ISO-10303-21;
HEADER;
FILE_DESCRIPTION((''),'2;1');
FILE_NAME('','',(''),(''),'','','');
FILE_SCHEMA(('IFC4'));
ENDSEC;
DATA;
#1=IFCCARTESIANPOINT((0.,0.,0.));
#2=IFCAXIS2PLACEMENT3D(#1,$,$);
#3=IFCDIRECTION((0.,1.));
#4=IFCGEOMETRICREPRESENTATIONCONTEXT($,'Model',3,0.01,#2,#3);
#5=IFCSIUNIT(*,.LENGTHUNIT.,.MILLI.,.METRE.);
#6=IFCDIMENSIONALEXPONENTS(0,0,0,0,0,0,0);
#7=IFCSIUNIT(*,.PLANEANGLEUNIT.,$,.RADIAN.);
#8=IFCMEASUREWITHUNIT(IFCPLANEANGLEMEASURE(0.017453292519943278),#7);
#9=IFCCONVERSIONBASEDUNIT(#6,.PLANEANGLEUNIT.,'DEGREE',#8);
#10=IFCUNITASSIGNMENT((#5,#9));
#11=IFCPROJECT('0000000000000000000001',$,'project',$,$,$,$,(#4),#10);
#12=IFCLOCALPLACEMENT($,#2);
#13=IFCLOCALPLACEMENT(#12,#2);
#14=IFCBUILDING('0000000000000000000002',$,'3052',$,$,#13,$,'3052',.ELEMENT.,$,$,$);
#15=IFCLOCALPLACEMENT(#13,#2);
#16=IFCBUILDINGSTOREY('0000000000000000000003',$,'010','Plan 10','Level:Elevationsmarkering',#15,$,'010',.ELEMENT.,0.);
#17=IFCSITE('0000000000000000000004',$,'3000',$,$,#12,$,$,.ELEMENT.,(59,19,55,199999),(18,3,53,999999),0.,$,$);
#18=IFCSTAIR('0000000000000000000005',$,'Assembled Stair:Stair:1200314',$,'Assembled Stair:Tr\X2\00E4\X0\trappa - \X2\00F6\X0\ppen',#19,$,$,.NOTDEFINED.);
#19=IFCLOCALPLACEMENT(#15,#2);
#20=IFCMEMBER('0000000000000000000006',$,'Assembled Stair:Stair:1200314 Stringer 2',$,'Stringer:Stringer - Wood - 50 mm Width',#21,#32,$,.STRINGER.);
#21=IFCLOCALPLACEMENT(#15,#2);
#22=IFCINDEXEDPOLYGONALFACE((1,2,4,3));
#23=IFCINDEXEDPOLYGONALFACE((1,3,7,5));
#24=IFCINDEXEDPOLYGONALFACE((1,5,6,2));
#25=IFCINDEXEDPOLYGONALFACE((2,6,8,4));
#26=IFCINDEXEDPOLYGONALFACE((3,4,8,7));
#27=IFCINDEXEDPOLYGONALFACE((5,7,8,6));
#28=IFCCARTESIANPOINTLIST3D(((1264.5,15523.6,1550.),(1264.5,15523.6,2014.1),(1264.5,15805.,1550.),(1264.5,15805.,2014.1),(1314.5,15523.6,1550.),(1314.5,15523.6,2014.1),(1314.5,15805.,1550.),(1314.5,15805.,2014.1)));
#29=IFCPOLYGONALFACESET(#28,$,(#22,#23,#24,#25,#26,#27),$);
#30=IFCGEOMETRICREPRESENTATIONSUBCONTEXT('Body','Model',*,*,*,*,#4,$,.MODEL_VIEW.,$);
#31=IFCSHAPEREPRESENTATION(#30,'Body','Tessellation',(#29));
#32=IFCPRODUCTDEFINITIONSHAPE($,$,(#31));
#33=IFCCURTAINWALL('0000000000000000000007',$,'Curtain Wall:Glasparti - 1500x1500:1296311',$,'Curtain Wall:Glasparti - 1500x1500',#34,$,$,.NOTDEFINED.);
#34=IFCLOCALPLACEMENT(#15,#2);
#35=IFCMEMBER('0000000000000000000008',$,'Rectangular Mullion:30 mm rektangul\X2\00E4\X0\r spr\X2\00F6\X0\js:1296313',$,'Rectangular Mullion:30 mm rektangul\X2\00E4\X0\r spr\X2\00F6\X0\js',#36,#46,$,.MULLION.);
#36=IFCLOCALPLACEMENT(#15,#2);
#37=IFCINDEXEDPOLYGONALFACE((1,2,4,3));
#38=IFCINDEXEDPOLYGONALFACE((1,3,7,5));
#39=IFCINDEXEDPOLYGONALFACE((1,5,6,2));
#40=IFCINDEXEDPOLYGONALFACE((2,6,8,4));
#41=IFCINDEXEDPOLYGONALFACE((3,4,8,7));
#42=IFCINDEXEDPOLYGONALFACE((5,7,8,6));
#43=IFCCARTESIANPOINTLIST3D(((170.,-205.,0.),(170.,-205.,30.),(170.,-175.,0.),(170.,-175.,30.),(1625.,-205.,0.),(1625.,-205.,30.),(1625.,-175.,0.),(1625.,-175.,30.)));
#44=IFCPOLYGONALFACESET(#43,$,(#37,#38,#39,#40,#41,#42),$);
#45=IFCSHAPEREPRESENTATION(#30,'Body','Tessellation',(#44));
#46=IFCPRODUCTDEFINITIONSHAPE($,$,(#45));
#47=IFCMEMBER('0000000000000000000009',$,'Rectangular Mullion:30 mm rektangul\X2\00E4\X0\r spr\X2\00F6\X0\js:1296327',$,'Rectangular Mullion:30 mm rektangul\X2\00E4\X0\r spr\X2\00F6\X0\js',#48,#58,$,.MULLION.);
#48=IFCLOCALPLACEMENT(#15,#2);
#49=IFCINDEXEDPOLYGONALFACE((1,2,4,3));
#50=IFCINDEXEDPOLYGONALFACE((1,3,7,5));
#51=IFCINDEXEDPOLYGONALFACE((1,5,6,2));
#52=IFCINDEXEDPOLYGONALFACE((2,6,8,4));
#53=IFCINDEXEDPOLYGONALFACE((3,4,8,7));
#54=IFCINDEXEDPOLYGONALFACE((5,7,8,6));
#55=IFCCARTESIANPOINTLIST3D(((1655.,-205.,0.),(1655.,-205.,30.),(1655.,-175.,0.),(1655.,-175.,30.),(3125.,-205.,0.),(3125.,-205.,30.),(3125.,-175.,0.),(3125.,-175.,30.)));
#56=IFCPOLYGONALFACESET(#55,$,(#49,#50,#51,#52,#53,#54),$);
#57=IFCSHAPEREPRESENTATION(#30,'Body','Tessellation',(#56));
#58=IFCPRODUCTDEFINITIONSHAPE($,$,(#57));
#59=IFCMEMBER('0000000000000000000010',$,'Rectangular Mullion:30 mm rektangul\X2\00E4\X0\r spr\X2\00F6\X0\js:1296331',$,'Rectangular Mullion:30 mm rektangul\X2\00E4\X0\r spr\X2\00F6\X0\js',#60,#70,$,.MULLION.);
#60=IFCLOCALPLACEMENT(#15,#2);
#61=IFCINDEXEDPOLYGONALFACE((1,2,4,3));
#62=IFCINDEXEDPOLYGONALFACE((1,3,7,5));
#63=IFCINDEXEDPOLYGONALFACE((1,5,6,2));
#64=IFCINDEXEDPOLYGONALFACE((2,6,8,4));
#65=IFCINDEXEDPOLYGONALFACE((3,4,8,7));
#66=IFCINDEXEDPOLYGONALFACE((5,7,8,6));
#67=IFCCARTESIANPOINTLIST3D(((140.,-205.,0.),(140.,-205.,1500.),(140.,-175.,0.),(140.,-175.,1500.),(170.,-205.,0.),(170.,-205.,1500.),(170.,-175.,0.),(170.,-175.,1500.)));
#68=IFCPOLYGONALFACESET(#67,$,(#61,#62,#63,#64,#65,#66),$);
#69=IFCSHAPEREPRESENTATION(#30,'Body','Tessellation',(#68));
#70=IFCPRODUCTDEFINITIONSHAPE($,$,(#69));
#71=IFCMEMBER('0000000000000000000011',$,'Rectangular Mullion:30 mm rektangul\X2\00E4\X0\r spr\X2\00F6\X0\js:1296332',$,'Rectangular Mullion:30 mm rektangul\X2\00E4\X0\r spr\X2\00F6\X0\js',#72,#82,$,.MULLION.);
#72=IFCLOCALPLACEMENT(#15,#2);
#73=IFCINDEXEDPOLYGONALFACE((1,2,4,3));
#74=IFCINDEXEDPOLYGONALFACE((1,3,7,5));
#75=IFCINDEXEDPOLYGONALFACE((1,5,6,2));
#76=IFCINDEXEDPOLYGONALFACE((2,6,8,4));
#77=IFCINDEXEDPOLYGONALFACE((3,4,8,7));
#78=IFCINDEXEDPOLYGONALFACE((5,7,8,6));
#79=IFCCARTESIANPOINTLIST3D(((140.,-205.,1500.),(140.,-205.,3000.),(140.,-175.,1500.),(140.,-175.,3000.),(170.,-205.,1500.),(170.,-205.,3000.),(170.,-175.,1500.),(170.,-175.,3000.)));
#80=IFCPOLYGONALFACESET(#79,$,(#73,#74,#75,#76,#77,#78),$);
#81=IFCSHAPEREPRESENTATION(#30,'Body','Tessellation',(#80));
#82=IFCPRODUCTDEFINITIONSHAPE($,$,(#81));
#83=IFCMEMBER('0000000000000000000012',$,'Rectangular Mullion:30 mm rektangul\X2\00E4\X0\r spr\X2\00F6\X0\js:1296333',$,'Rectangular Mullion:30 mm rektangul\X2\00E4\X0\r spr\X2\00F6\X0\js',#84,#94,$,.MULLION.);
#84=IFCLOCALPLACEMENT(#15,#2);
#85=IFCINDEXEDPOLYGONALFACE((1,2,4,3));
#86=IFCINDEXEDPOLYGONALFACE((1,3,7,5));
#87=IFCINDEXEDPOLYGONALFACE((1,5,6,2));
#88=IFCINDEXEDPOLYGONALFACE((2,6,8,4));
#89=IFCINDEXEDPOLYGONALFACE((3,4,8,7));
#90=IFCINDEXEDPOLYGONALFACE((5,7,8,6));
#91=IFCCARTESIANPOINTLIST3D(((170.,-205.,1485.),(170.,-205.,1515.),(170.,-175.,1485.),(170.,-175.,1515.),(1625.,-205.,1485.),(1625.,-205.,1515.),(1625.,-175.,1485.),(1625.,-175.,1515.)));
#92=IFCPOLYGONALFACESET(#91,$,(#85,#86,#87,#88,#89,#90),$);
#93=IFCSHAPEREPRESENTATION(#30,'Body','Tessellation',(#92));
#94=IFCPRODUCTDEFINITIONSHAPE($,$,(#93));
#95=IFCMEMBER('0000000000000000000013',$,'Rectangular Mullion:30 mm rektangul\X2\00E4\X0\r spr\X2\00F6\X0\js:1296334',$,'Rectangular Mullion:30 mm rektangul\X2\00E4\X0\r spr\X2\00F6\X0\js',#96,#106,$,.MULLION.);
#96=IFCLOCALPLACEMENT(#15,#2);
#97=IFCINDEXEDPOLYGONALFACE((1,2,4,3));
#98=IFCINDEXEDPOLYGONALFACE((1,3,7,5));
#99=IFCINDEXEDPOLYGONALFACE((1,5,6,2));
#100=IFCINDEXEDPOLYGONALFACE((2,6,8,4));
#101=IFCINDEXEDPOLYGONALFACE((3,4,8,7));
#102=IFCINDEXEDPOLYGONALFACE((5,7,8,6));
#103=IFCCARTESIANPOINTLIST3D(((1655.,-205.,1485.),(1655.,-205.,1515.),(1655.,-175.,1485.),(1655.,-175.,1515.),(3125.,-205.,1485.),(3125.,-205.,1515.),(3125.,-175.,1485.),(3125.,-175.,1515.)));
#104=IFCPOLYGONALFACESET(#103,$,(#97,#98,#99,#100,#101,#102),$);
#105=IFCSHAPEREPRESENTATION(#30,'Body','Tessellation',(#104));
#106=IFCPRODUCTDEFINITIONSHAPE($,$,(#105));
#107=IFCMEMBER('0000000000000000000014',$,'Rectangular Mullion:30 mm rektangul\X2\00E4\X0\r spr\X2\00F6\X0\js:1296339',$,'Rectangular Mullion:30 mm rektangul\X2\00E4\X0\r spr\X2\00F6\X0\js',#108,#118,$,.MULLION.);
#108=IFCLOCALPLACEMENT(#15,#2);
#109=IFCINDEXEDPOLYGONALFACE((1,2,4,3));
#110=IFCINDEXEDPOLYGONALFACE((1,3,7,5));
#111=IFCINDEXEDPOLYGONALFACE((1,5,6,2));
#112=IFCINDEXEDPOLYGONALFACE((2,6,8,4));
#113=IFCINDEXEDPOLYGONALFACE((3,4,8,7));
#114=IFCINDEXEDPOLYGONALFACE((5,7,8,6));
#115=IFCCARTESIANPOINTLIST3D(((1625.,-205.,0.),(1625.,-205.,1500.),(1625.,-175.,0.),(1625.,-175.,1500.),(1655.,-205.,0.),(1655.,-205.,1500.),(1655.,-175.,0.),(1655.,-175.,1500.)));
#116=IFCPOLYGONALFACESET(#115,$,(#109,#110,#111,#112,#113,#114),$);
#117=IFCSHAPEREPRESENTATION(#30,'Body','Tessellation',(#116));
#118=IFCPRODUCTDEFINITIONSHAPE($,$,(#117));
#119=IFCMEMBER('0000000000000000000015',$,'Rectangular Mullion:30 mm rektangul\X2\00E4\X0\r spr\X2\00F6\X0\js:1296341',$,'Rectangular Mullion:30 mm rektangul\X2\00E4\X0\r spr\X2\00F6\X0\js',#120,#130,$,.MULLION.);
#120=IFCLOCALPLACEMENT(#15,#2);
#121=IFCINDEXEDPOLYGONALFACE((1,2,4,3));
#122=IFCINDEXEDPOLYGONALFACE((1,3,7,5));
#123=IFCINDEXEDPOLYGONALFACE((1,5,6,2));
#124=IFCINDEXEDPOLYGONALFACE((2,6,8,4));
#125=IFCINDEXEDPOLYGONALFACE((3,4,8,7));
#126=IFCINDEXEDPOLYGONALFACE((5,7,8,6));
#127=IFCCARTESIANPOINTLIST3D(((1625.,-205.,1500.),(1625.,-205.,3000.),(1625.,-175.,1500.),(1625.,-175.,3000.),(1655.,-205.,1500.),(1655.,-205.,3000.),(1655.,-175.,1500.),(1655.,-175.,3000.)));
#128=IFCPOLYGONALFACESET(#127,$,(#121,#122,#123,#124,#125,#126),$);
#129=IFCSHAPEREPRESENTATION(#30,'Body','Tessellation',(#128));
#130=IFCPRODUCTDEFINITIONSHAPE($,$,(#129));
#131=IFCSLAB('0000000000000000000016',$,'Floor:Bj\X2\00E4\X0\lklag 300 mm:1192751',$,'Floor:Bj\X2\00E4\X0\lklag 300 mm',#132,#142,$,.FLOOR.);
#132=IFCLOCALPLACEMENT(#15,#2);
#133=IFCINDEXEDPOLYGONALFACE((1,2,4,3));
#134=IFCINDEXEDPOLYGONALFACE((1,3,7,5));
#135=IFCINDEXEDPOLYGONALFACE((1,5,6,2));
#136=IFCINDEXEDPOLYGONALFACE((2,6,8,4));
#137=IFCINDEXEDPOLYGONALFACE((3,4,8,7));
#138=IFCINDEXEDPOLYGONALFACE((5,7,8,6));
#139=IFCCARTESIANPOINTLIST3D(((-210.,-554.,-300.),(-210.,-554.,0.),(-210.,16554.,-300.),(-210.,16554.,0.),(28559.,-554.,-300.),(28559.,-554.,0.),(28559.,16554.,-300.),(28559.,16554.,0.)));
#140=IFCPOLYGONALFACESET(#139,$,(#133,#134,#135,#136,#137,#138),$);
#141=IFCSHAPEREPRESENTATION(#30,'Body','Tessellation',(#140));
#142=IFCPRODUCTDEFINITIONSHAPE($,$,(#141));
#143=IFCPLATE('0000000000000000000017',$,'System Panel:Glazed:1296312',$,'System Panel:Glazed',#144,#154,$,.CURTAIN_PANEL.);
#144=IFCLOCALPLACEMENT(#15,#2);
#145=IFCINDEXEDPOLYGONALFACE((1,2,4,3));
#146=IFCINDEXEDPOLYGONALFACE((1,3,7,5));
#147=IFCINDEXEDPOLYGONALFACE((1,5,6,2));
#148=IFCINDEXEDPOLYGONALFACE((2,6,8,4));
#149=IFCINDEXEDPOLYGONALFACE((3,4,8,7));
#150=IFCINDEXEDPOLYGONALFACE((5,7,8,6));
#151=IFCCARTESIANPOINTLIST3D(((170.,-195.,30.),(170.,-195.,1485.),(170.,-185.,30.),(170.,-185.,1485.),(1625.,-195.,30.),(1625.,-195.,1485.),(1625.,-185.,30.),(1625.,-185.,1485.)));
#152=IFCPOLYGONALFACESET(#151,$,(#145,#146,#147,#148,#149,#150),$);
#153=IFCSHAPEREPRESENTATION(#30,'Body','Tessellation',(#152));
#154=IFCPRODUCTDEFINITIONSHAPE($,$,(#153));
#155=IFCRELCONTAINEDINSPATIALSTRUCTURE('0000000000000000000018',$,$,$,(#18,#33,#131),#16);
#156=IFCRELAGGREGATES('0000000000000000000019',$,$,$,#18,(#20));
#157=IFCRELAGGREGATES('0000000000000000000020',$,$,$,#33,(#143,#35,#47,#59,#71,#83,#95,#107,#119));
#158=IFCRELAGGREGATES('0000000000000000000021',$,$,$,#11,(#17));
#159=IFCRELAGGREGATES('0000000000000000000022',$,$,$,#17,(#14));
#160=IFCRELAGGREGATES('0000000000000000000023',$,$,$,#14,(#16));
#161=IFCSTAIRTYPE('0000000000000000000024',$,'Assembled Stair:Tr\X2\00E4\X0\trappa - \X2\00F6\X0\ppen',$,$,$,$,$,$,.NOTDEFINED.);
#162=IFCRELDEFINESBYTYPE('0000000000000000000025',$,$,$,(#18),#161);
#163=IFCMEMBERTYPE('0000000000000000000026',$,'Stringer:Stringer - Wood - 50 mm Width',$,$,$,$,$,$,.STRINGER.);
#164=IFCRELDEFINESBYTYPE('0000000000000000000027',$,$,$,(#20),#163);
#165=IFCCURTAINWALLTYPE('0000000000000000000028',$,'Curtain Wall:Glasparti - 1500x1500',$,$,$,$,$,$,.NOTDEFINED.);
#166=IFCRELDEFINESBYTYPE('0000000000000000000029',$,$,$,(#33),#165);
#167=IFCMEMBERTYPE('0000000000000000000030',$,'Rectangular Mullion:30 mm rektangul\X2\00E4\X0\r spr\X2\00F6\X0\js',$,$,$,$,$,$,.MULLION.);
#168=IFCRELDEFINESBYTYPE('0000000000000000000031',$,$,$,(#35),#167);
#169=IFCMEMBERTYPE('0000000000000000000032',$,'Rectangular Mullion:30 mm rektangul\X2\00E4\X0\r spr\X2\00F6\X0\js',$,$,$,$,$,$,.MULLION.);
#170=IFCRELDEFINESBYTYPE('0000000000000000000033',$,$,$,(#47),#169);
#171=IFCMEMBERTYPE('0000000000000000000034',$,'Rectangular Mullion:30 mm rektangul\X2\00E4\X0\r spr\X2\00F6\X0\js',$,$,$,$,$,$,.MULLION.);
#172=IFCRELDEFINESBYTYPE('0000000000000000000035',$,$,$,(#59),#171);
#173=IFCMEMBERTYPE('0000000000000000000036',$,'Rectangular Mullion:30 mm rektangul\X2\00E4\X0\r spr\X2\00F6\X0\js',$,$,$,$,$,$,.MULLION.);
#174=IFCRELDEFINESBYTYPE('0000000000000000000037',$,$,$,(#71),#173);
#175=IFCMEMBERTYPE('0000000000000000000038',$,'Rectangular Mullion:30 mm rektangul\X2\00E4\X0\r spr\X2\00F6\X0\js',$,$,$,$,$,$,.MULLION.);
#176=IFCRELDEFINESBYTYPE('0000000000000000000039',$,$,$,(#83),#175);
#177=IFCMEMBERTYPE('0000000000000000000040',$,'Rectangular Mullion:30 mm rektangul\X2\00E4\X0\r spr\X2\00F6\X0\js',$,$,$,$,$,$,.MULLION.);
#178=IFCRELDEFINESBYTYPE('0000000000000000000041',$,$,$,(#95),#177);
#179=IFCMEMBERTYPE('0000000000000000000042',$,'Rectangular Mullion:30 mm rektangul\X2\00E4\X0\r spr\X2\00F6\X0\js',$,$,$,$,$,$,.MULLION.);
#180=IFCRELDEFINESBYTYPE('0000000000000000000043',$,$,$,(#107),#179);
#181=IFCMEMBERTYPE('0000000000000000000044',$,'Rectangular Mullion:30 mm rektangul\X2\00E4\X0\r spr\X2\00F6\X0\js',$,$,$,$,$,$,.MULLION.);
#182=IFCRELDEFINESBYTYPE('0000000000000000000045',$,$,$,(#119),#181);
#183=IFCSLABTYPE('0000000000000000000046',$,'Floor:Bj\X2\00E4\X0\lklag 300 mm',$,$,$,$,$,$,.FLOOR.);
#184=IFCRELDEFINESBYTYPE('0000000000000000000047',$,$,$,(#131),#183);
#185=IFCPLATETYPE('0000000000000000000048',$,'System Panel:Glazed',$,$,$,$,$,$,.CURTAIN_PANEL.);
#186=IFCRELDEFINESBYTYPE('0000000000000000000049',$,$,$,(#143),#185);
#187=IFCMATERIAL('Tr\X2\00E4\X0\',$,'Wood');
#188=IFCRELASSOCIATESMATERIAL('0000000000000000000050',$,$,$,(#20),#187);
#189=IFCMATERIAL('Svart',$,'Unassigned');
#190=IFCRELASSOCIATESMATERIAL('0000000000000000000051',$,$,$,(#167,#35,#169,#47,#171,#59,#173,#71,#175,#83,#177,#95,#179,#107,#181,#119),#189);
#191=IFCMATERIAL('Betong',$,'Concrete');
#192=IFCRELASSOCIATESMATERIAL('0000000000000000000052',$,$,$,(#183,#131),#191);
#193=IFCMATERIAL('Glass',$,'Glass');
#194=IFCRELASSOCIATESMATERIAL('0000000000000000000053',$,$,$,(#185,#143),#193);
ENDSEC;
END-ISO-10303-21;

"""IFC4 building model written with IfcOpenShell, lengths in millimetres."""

from ifc_helpers import new_model, entity, si_unit, converted_unit, direction, frame, origin, place, context, subcontext, project, spatial, indexed_curve, outline, extrude, source, transform, mapped, material, type_object, type_shapes, element, aggregate, save


model = new_model("IFC4")

# Units and contexts
model_context = context("Model", 3, precision=0.01, world=origin(), true_north=direction((0.0, 1.0)))
body_context = subcontext(model_context, "Body", "Model", "MODEL_VIEW")
ifc_project = project(units=[si_unit("LENGTHUNIT", "METRE", prefix="MILLI"), converted_unit("PLANEANGLEUNIT", "DEGREE", entity("IfcPlaneAngleMeasure", 0.017453292519943278), si_unit("PLANEANGLEUNIT", "RADIAN"), dimensions=[0, 0, 0, 0, 0, 0, 0])], contexts=[model_context])

# Site, building, storey
site_placement = place(None, origin())
site = spatial("IfcSite", under=ifc_project, at=site_placement, Name="3000", CompositionType="ELEMENT", RefLatitude=(59, 19, 55, 199999), RefLongitude=(18, 3, 53, 999999), RefElevation=0.0)
building_placement = place(site_placement, origin())
building = spatial("IfcBuilding", under=site, at=building_placement, Name="3052", LongName="3052", CompositionType="ELEMENT")
storey_placement = place(building_placement, origin())
storey = spatial("IfcBuildingStorey", under=building, at=storey_placement, Name="010", Description="Plan 10", ObjectType="Level:Elevationsmarkering", LongName="010", CompositionType="ELEMENT", Elevation=0.0)

# Stair, member
stair_type = type_object("IfcStairType", Name="Assembled Stair:Trätrappa - öppen", PredefinedType="NOTDEFINED")
stair_placement = place(storey_placement, origin())
stair = element("IfcStair", 1, at=stair_placement, inside=storey, type_object=stair_type, Name="Assembled Stair:Stair:1200314", ObjectType="Assembled Stair:Trätrappa - öppen", PredefinedType="NOTDEFINED")
ifc_material_1 = material(Name="Trä", Category="Wood")
member_type_1 = type_object("IfcMemberType", Name="Stringer:Stringer - Wood - 50 mm Width", PredefinedType="STRINGER")
member_1_placement = place(stair_placement, origin())
member_1 = element("IfcMember", 2, at=member_1_placement, type_object=member_type_1, material=ifc_material_1, Name="Assembled Stair:Stair:1200314 Stringer 2", ObjectType="Stringer:Stringer - Wood - 50 mm Width", PredefinedType="STRINGER", context=body_context, shape_type="SweptSolid", body=[
    extrude(outline(indexed_curve([(-140.7, -25.0), (140.7, -25.0), (140.7, 25.0), (-140.7, 25.0), (-140.7, -25.0)], self_intersect=False)), frame((1289.5, 15664.3, 1550.0), z_axis=(0.0, 0.0, 1.0), x_axis=(0.0, 1.0, 0.0)), (0.0, 0.0, 1.0), 464.1),
])
aggregate(stair, [member_1])

# Curtain wall, members
curtain_wall_type = type_object("IfcCurtainWallType", Name="Curtain Wall:Glasparti - 1500x1500", PredefinedType="NOTDEFINED")
curtain_wall_placement = place(storey_placement, origin())
curtain_wall = element("IfcCurtainWall", 3, at=curtain_wall_placement, inside=storey, type_object=curtain_wall_type, Name="Curtain Wall:Glasparti - 1500x1500:1296311", ObjectType="Curtain Wall:Glasparti - 1500x1500", PredefinedType="NOTDEFINED")
ifc_material_2 = material(Name="Svart", Category="Unassigned")
member_type_2 = type_object("IfcMemberType", Name="Rectangular Mullion:30 mm rektangulär spröjs", PredefinedType="MULLION", material=ifc_material_2)
shared_shape_1 = source(origin(), body_context, "Body", "SweptSolid", [
    extrude(outline(indexed_curve([(-15.0, -15.0), (15.0, -15.0), (15.0, 15.0), (-15.0, 15.0), (-15.0, -15.0)], self_intersect=False)), frame((-15.0, 0.0, -1455.0), z_axis=(0.0, 0.0, 1.0), x_axis=(-1.0, 0.0, 0.0)), (0.0, 0.0, 1.0), 1455.0),
])
type_shapes(member_type_2, [shared_shape_1])
member_2_placement = place(curtain_wall_placement, frame((170.0, -190.0, 0.0), z_axis=(-1.0, 0.0, 0.0), x_axis=(0.0, 0.0, -1.0)))
member_2 = element("IfcMember", 4, at=member_2_placement, type_object=member_type_2, material=ifc_material_2, Name="Rectangular Mullion:30 mm rektangulär spröjs:1296313", ObjectType="Rectangular Mullion:30 mm rektangulär spröjs", PredefinedType="MULLION", context=body_context, shape_type="MappedRepresentation", body=[
    mapped(shared_shape_1, transform((0.0, 0.0, 0.0), scale=1.0)),
])
member_type_3 = type_object("IfcMemberType", Name="Rectangular Mullion:30 mm rektangulär spröjs", PredefinedType="MULLION", material=ifc_material_2)
shared_shape_2 = source(origin(), body_context, "Body", "SweptSolid", [
    extrude(outline(indexed_curve([(-15.0, -15.0), (15.0, -15.0), (15.0, 15.0), (-15.0, 15.0), (-15.0, -15.0)], self_intersect=False)), frame((-15.0, 0.0, -1470.0), z_axis=(0.0, 0.0, 1.0), x_axis=(-1.0, 0.0, 0.0)), (0.0, 0.0, 1.0), 1470.0),
])
type_shapes(member_type_3, [shared_shape_2])
member_3_placement = place(curtain_wall_placement, frame((1655.0, -190.0, 0.0), z_axis=(-1.0, 0.0, 0.0), x_axis=(0.0, 0.0, -1.0)))
member_3 = element("IfcMember", 5, at=member_3_placement, type_object=member_type_3, material=ifc_material_2, Name="Rectangular Mullion:30 mm rektangulär spröjs:1296327", ObjectType="Rectangular Mullion:30 mm rektangulär spröjs", PredefinedType="MULLION", context=body_context, shape_type="MappedRepresentation", body=[
    mapped(shared_shape_2, transform((0.0, 0.0, 0.0), scale=1.0)),
])
member_type_4 = type_object("IfcMemberType", Name="Rectangular Mullion:30 mm rektangulär spröjs", PredefinedType="MULLION", material=ifc_material_2)
shared_shape_3 = source(origin(), body_context, "Body", "SweptSolid", [
    extrude(outline(indexed_curve([(-15.0, -15.0), (15.0, -15.0), (15.0, 15.0), (-15.0, 15.0), (-15.0, -15.0)], self_intersect=False)), frame((-15.0, 0.0, -1500.0), z_axis=(0.0, 0.0, 1.0), x_axis=(-1.0, 0.0, 0.0)), (0.0, 0.0, 1.0), 1500.0),
])
type_shapes(member_type_4, [shared_shape_3])
member_4_placement = place(curtain_wall_placement, frame((140.0, -190.0, 1500.0), z_axis=(0.0, 0.0, 1.0), x_axis=(-1.0, 0.0, 0.0)))
member_4 = element("IfcMember", 6, at=member_4_placement, type_object=member_type_4, material=ifc_material_2, Name="Rectangular Mullion:30 mm rektangulär spröjs:1296331", ObjectType="Rectangular Mullion:30 mm rektangulär spröjs", PredefinedType="MULLION", context=body_context, shape_type="MappedRepresentation", body=[
    mapped(shared_shape_3, transform((0.0, 0.0, 0.0), scale=1.0)),
])
member_type_5 = type_object("IfcMemberType", Name="Rectangular Mullion:30 mm rektangulär spröjs", PredefinedType="MULLION", material=ifc_material_2)
shared_shape_4 = source(origin(), body_context, "Body", "SweptSolid", [
    extrude(outline(indexed_curve([(-15.0, -15.0), (15.0, -15.0), (15.0, 15.0), (-15.0, 15.0), (-15.0, -15.0)], self_intersect=False)), frame((-15.0, 0.0, -1500.0), z_axis=(0.0, 0.0, 1.0), x_axis=(-1.0, 0.0, 0.0)), (0.0, 0.0, 1.0), 1500.0),
])
type_shapes(member_type_5, [shared_shape_4])
member_5_placement = place(curtain_wall_placement, frame((140.0, -190.0, 3000.0), z_axis=(0.0, 0.0, 1.0), x_axis=(-1.0, 0.0, 0.0)))
member_5 = element("IfcMember", 7, at=member_5_placement, type_object=member_type_5, material=ifc_material_2, Name="Rectangular Mullion:30 mm rektangulär spröjs:1296332", ObjectType="Rectangular Mullion:30 mm rektangulär spröjs", PredefinedType="MULLION", context=body_context, shape_type="MappedRepresentation", body=[
    mapped(shared_shape_4, transform((0.0, 0.0, 0.0), scale=1.0)),
])
member_type_6 = type_object("IfcMemberType", Name="Rectangular Mullion:30 mm rektangulär spröjs", PredefinedType="MULLION", material=ifc_material_2)
shared_shape_5 = source(origin(), body_context, "Body", "SweptSolid", [
    extrude(outline(indexed_curve([(-15.0, -15.0), (15.0, -15.0), (15.0, 15.0), (-15.0, 15.0), (-15.0, -15.0)], self_intersect=False)), frame((0.0, 0.0, -1455.0), z_axis=(0.0, 0.0, 1.0), x_axis=(-1.0, 0.0, 0.0)), (0.0, 0.0, 1.0), 1455.0),
])
type_shapes(member_type_6, [shared_shape_5])
member_6_placement = place(curtain_wall_placement, frame((1625.0, -190.0, 1500.0), z_axis=(1.0, 0.0, 0.0), x_axis=(0.0, 0.0, 1.0)))
member_6 = element("IfcMember", 8, at=member_6_placement, type_object=member_type_6, material=ifc_material_2, Name="Rectangular Mullion:30 mm rektangulär spröjs:1296333", ObjectType="Rectangular Mullion:30 mm rektangulär spröjs", PredefinedType="MULLION", context=body_context, shape_type="MappedRepresentation", body=[
    mapped(shared_shape_5, transform((0.0, 0.0, 0.0), scale=1.0)),
])
member_type_7 = type_object("IfcMemberType", Name="Rectangular Mullion:30 mm rektangulär spröjs", PredefinedType="MULLION", material=ifc_material_2)
shared_shape_6 = source(origin(), body_context, "Body", "SweptSolid", [
    extrude(outline(indexed_curve([(-15.0, -15.0), (15.0, -15.0), (15.0, 15.0), (-15.0, 15.0), (-15.0, -15.0)], self_intersect=False)), frame((0.0, 0.0, -1470.0), z_axis=(0.0, 0.0, 1.0), x_axis=(-1.0, 0.0, 0.0)), (0.0, 0.0, 1.0), 1470.0),
])
type_shapes(member_type_7, [shared_shape_6])
member_7_placement = place(curtain_wall_placement, frame((3125.0, -190.0, 1500.0), z_axis=(1.0, 0.0, 0.0), x_axis=(0.0, 0.0, 1.0)))
member_7 = element("IfcMember", 9, at=member_7_placement, type_object=member_type_7, material=ifc_material_2, Name="Rectangular Mullion:30 mm rektangulär spröjs:1296334", ObjectType="Rectangular Mullion:30 mm rektangulär spröjs", PredefinedType="MULLION", context=body_context, shape_type="MappedRepresentation", body=[
    mapped(shared_shape_6, transform((0.0, 0.0, 0.0), scale=1.0)),
])
member_type_8 = type_object("IfcMemberType", Name="Rectangular Mullion:30 mm rektangulär spröjs", PredefinedType="MULLION", material=ifc_material_2)
shared_shape_7 = source(origin(), body_context, "Body", "SweptSolid", [
    extrude(outline(indexed_curve([(-15.0, -15.0), (15.0, -15.0), (15.0, 15.0), (-15.0, 15.0), (-15.0, -15.0)], self_intersect=False)), frame((0.0, 0.0, -1500.0), z_axis=(0.0, 0.0, 1.0), x_axis=(-1.0, 0.0, 0.0)), (0.0, 0.0, 1.0), 1500.0),
])
type_shapes(member_type_8, [shared_shape_7])
member_8_placement = place(curtain_wall_placement, frame((1640.0, -190.0, 0.0), z_axis=(0.0, 0.0, -1.0), x_axis=(1.0, 0.0, 0.0)))
member_8 = element("IfcMember", 10, at=member_8_placement, type_object=member_type_8, material=ifc_material_2, Name="Rectangular Mullion:30 mm rektangulär spröjs:1296339", ObjectType="Rectangular Mullion:30 mm rektangulär spröjs", PredefinedType="MULLION", context=body_context, shape_type="MappedRepresentation", body=[
    mapped(shared_shape_7, transform((0.0, 0.0, 0.0), scale=1.0)),
])
member_type_9 = type_object("IfcMemberType", Name="Rectangular Mullion:30 mm rektangulär spröjs", PredefinedType="MULLION", material=ifc_material_2)
shared_shape_8 = source(origin(), body_context, "Body", "SweptSolid", [
    extrude(outline(indexed_curve([(-15.0, -15.0), (15.0, -15.0), (15.0, 15.0), (-15.0, 15.0), (-15.0, -15.0)], self_intersect=False)), frame((0.0, 0.0, -1500.0), z_axis=(0.0, 0.0, 1.0), x_axis=(-1.0, 0.0, 0.0)), (0.0, 0.0, 1.0), 1500.0),
])
type_shapes(member_type_9, [shared_shape_8])
member_9_placement = place(curtain_wall_placement, frame((1640.0, -190.0, 1500.0), z_axis=(0.0, 0.0, -1.0), x_axis=(1.0, 0.0, 0.0)))
member_9 = element("IfcMember", 11, at=member_9_placement, type_object=member_type_9, material=ifc_material_2, Name="Rectangular Mullion:30 mm rektangulär spröjs:1296341", ObjectType="Rectangular Mullion:30 mm rektangulär spröjs", PredefinedType="MULLION", context=body_context, shape_type="MappedRepresentation", body=[
    mapped(shared_shape_8, transform((0.0, 0.0, 0.0), scale=1.0)),
])

# Slab
ifc_material_3 = material(Name="Betong", Category="Concrete")
slab_type = type_object("IfcSlabType", Name="Floor:Bjälklag 300 mm", PredefinedType="FLOOR", material=ifc_material_3)
slab_placement = place(storey_placement, origin())
element("IfcSlab", 12, at=slab_placement, inside=storey, type_object=slab_type, material=ifc_material_3, Name="Floor:Bjälklag 300 mm:1192751", ObjectType="Floor:Bjälklag 300 mm", PredefinedType="FLOOR", context=body_context, shape_type="SweptSolid", body=[
    extrude(outline(indexed_curve([(-8554.0, -14384.5), (8554.0, -14384.5), (8554.0, 14384.5), (-8554.0, 14384.5), (-8554.0, -14384.5)], self_intersect=False)), frame((14174.5, 8000.0, 0.0), z_axis=(0.0, 0.0, -1.0), x_axis=(0.0, 1.0, 0.0)), (0.0, 0.0, 1.0), 300.0),
])

# Plate
ifc_material_4 = material(Name="Glass", Category="Glass")
plate_type_1 = type_object("IfcPlateType", Name="System Panel:Glazed", PredefinedType="CURTAIN_PANEL", material=ifc_material_4)
shared_shape_9 = source(origin(), body_context, "Body", "SweptSolid", [
    extrude(outline(indexed_curve([(-5.0, -727.5), (5.0, -727.5), (5.0, 727.5), (-5.0, 727.5), (-5.0, -727.5)], self_intersect=False)), frame((0.0, 0.0, 0.0), z_axis=(0.0, 0.0, 1.0), x_axis=(0.0, 1.0, 0.0)), (0.0, 0.0, 1.0), 1455.0),
])
type_shapes(plate_type_1, [shared_shape_9])
plate_1_placement = place(curtain_wall_placement, frame((897.5, -190.0, 30.0)))
plate_1 = element("IfcPlate", 13, at=plate_1_placement, type_object=plate_type_1, material=ifc_material_4, Name="System Panel:Glazed:1296312", ObjectType="System Panel:Glazed", PredefinedType="CURTAIN_PANEL", context=body_context, shape_type="MappedRepresentation", body=[
    mapped(shared_shape_9, transform((0.0, 0.0, 0.0), scale=1.0)),
])
aggregate(curtain_wall, [plate_1, member_2, member_3, member_4, member_5, member_6, member_7, member_8, member_9])

save(model, "model.ifc")
